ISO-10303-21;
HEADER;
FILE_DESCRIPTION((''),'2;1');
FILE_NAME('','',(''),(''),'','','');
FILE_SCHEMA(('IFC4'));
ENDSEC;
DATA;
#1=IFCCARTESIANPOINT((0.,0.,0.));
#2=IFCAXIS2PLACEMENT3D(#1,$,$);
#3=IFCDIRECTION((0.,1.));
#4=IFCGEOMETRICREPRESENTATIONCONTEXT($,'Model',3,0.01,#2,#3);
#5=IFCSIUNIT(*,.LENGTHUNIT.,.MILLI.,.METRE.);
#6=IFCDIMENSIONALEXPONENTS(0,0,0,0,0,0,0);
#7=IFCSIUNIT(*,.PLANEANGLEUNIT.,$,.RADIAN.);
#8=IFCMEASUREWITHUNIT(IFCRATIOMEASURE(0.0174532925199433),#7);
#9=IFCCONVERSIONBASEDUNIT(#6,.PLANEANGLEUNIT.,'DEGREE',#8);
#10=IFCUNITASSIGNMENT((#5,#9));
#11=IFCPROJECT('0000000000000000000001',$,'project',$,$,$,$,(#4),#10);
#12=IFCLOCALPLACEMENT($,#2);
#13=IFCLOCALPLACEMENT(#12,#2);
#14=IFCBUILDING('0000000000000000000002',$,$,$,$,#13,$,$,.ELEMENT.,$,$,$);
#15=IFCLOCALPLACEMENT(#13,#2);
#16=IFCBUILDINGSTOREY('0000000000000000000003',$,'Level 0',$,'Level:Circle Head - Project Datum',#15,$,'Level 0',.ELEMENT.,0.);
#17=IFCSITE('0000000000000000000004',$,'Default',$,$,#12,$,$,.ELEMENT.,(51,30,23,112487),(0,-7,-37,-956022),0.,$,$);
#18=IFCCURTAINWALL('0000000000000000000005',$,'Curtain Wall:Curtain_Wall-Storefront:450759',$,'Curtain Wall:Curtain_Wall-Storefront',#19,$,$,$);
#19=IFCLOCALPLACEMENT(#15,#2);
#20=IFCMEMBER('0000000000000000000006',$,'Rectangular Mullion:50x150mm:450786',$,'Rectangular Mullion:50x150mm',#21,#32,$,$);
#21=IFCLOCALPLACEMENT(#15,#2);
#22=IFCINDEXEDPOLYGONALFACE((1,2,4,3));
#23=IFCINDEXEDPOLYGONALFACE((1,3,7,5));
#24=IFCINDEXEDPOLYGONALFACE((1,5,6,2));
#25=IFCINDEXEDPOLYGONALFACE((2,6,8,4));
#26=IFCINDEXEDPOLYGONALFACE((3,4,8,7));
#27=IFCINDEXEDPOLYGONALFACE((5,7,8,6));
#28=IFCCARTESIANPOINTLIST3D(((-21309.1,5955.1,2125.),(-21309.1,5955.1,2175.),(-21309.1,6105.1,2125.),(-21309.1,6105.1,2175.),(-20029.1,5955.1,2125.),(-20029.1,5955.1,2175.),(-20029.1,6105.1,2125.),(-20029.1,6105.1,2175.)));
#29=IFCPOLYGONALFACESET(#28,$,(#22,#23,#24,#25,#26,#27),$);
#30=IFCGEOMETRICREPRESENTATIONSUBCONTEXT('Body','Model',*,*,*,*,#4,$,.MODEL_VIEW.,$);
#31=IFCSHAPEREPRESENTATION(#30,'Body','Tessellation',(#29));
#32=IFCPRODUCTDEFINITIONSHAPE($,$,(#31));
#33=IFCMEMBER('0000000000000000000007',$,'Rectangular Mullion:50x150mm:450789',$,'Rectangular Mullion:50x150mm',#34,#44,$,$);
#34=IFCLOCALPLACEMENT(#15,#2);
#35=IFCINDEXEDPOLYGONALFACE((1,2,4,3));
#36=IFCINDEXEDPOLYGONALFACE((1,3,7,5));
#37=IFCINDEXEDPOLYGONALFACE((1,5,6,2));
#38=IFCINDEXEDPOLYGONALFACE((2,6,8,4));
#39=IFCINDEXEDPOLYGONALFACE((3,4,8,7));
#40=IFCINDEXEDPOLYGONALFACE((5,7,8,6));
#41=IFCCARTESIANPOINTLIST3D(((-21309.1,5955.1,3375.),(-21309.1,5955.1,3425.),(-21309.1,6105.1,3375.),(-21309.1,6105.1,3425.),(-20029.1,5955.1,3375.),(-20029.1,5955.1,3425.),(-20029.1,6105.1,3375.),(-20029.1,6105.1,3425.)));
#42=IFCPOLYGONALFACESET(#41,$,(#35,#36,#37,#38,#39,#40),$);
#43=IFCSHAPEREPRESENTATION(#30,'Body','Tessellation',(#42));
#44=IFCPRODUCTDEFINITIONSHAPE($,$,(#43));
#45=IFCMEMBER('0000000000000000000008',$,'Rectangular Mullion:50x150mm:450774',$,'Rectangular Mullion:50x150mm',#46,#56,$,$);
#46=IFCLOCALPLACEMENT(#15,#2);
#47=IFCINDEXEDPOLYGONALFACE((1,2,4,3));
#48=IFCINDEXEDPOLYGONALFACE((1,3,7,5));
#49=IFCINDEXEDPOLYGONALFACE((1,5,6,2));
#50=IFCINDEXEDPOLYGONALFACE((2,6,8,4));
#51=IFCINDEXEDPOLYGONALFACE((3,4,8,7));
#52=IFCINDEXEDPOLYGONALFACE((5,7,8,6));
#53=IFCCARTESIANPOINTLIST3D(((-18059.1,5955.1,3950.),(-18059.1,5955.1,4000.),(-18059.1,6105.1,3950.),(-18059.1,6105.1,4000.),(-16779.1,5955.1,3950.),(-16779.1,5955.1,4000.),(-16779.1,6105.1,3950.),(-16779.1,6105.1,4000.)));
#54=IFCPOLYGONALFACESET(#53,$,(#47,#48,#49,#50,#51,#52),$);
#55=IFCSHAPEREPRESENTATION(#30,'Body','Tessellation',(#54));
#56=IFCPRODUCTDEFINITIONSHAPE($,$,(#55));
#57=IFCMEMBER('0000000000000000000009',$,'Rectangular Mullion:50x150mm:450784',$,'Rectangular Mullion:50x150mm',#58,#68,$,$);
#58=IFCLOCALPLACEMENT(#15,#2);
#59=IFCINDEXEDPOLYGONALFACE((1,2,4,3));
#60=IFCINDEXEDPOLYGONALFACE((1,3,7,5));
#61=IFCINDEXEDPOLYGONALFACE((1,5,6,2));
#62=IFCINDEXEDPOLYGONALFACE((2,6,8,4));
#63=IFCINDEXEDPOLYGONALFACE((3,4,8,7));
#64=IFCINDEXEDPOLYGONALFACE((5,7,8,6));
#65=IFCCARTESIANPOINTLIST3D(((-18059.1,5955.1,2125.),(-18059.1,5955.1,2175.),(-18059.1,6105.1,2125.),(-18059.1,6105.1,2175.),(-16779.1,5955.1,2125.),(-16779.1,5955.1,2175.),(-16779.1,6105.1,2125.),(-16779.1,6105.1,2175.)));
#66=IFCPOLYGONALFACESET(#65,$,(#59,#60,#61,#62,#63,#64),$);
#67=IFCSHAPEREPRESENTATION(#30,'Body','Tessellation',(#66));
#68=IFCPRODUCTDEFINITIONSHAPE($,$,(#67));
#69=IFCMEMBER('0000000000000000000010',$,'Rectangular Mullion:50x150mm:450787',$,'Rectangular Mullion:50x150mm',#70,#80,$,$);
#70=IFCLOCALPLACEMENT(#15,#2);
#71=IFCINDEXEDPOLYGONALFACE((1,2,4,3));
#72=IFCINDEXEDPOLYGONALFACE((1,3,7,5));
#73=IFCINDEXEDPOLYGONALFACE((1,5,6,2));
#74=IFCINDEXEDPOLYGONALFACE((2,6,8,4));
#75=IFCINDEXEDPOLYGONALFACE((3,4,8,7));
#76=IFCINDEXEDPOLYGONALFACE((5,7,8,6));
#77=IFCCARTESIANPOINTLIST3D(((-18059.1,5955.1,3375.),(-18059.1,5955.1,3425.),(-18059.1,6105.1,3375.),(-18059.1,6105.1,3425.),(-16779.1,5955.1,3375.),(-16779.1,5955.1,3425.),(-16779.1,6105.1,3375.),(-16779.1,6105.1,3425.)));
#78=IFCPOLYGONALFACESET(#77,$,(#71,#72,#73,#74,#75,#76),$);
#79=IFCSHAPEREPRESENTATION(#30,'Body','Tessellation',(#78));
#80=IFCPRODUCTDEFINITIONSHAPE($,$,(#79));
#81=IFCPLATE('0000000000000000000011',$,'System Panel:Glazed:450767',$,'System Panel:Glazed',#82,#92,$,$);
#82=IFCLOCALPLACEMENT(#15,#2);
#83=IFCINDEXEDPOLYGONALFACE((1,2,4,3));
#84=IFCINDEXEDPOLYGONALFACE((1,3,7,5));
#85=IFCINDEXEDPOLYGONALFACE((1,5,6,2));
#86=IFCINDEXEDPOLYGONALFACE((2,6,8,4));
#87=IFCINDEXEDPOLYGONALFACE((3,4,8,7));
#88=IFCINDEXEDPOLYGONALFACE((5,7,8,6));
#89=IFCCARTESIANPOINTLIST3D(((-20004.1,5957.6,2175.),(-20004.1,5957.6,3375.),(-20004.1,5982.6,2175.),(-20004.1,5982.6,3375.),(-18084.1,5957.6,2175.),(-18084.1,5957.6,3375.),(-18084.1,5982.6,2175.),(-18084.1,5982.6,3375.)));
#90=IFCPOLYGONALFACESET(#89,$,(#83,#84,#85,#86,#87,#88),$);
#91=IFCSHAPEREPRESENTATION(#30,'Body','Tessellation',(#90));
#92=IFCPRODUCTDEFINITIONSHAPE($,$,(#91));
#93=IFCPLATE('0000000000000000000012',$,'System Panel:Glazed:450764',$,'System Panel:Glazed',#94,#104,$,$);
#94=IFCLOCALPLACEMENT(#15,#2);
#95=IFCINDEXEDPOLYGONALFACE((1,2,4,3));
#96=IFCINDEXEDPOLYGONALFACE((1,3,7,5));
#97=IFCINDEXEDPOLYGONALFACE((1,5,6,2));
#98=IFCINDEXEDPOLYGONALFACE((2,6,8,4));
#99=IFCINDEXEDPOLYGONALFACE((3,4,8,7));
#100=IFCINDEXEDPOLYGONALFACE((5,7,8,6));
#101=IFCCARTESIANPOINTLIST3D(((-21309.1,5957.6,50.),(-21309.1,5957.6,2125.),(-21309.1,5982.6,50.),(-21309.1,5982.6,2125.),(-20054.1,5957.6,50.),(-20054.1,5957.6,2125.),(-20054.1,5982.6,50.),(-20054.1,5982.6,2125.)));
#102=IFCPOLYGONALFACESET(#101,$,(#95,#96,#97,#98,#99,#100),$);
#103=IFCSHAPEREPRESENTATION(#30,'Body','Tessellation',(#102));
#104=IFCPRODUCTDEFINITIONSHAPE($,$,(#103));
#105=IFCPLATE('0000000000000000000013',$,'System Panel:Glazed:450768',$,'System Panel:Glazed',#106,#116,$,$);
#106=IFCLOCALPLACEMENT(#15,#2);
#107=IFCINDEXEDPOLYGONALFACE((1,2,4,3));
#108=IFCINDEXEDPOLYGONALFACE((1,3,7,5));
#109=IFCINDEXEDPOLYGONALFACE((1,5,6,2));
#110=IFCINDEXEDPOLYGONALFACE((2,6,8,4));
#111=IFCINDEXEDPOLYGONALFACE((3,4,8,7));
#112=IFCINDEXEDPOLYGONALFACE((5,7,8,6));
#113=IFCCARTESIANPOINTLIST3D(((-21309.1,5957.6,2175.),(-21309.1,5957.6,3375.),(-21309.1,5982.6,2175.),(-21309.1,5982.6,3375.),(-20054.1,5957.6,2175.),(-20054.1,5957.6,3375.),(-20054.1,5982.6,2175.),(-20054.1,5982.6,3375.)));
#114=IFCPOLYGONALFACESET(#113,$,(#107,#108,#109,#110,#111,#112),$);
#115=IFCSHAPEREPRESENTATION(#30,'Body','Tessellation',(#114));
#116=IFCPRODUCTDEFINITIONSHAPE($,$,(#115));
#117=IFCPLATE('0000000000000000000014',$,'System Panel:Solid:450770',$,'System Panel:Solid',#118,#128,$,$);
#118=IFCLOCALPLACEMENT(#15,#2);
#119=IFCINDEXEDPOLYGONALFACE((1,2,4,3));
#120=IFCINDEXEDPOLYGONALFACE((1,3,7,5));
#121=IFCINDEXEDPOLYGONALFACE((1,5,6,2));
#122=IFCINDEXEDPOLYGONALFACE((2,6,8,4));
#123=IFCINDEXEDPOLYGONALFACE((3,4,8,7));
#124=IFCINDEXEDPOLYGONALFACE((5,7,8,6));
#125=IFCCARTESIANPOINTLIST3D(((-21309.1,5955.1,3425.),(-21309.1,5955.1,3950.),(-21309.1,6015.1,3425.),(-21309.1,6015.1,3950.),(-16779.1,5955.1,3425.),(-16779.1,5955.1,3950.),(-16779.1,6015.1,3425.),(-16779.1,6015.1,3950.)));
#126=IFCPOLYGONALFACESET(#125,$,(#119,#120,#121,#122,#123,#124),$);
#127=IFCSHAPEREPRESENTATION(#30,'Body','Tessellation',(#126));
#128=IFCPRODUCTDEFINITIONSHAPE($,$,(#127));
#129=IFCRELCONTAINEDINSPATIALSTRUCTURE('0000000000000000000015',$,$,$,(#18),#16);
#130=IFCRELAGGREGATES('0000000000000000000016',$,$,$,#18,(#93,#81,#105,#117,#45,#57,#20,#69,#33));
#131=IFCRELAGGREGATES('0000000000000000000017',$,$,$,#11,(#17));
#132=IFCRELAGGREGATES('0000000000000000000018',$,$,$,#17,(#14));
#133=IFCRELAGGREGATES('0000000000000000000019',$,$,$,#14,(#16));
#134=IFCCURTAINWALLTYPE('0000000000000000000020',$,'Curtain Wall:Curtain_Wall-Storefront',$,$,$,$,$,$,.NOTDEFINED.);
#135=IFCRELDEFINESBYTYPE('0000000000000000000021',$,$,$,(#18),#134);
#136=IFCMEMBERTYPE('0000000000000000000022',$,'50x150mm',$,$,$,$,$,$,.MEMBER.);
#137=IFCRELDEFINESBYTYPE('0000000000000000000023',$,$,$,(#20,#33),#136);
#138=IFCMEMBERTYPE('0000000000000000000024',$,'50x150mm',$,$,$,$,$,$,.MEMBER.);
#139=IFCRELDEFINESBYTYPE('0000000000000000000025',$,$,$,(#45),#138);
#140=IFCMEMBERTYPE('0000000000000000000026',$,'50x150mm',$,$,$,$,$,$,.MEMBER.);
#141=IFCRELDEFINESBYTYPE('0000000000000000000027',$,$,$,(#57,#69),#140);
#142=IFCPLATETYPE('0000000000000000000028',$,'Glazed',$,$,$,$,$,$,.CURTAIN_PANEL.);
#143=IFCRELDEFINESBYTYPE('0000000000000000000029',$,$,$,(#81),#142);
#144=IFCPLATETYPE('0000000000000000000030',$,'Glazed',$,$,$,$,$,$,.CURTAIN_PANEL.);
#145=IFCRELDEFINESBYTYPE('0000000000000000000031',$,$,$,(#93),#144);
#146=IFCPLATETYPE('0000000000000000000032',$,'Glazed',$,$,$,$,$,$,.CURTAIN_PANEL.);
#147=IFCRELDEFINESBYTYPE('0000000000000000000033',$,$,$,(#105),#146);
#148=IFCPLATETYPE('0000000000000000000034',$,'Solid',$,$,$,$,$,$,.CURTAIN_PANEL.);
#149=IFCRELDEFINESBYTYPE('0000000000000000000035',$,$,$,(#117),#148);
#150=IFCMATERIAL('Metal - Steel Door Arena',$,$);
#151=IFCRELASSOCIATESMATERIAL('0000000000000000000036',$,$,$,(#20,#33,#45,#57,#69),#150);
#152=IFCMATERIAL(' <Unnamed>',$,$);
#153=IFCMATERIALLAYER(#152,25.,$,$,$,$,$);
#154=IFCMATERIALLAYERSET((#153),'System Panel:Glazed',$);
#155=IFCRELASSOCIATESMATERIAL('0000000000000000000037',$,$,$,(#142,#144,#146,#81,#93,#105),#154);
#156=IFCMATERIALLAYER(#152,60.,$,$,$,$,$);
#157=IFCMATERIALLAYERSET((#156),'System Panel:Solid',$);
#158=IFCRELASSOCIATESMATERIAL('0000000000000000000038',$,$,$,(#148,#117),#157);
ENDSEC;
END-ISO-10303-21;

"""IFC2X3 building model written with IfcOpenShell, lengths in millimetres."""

from ifc_helpers import new_model, entity, si_unit, converted_unit, direction, frame, frame_2d, origin, origin_2d_with_axis, place, context, subcontext, project, spatial, rectangle, extrude, source, transform, mapped, material, layer, layer_set, layer_usage, type_object, type_shapes, element, aggregate, save


model = new_model("IFC2X3")

# Units and contexts
model_context = context("Model", 3, precision=0.01, world=origin(), true_north=direction((0.0, 1.0)))
body_context = subcontext(model_context, "Body", "Model", "MODEL_VIEW")
ifc_project = project(units=[si_unit("LENGTHUNIT", "METRE", prefix="MILLI"), converted_unit("PLANEANGLEUNIT", "DEGREE", entity("IfcRatioMeasure", 0.0174532925199433), si_unit("PLANEANGLEUNIT", "RADIAN"), dimensions=[0, 0, 0, 0, 0, 0, 0])], contexts=[model_context])

# Site, building, storey
site_placement = place(None, origin())
site = spatial("IfcSite", under=ifc_project, at=site_placement, Name="Default", CompositionType="ELEMENT", RefLatitude=(51, 30, 23, 112487), RefLongitude=(0, -7, -37, -956022), RefElevation=0.0)
building_placement = place(site_placement, origin())
building = spatial("IfcBuilding", under=site, at=building_placement, CompositionType="ELEMENT")
storey_placement = place(building_placement, origin())
storey = spatial("IfcBuildingStorey", under=building, at=storey_placement, Name="Level 0", ObjectType="Level:Circle Head - Project Datum", LongName="Level 0", CompositionType="ELEMENT", Elevation=0.0)

# Curtain wall, members, plates
curtain_wall_type = type_object("IfcCurtainWallType", Name="Curtain Wall:Curtain_Wall-Storefront", PredefinedType="NOTDEFINED")
curtain_wall_placement = place(storey_placement, origin())
curtain_wall = element("IfcCurtainWall", 1, at=curtain_wall_placement, inside=storey, type_object=curtain_wall_type, Name="Curtain Wall:Curtain_Wall-Storefront:450759", ObjectType="Curtain Wall:Curtain_Wall-Storefront")
ifc_material_1 = material(Name="Metal - Steel Door Arena")
member_type_1 = type_object("IfcMemberType", Name="50x150mm", PredefinedType="MEMBER")
shared_shape_1 = source(origin(), body_context, "Body", "SweptSolid", [
    extrude(rectangle(XDim=150.0, YDim=50.0, at=origin_2d_with_axis()), frame((0.0, 0.0, -1280.0), z_axis=(0.0, 0.0, 1.0), x_axis=(0.0, -1.0, 0.0)), (0.0, 0.0, 1.0), 1280.0),
])
type_shapes(member_type_1, [shared_shape_1])
member_1_placement = place(storey_placement, frame((-21309.1, 6030.1, 2150.0), z_axis=(-1.0, 0.0, 0.0), x_axis=(0.0, 0.0, 1.0)))
member_1 = element("IfcMember", 2, at=member_1_placement, type_object=member_type_1, material=ifc_material_1, Name="Rectangular Mullion:50x150mm:450786", ObjectType="Rectangular Mullion:50x150mm", context=body_context, shape_type="MappedRepresentation", body=[
    mapped(shared_shape_1, transform((0.0, 0.0, 0.0), scale=1.0)),
])
member_2_placement = place(storey_placement, frame((-21309.1, 6030.1, 3400.0), z_axis=(-1.0, 0.0, 0.0), x_axis=(0.0, 0.0, 1.0)))
member_2 = element("IfcMember", 3, at=member_2_placement, type_object=member_type_1, material=ifc_material_1, Name="Rectangular Mullion:50x150mm:450789", ObjectType="Rectangular Mullion:50x150mm", context=body_context, shape_type="MappedRepresentation", body=[
    mapped(shared_shape_1, transform((0.0, 0.0, 0.0), scale=1.0)),
])
member_type_2 = type_object("IfcMemberType", Name="50x150mm", PredefinedType="MEMBER")
shared_shape_2 = source(origin(), body_context, "Body", "SweptSolid", [
    extrude(rectangle(XDim=150.0, YDim=50.0, at=origin_2d_with_axis()), frame((-25.0, 0.0, -1280.0), z_axis=(0.0, 0.0, 1.0), x_axis=(0.0, -1.0, 0.0)), (0.0, 0.0, 1.0), 1280.0),
])
type_shapes(member_type_2, [shared_shape_2])
member_3_placement = place(storey_placement, frame((-18059.1, 6030.1, 4000.0), z_axis=(-1.0, 0.0, 0.0), x_axis=(0.0, 0.0, 1.0)))
member_3 = element("IfcMember", 4, at=member_3_placement, type_object=member_type_2, material=ifc_material_1, Name="Rectangular Mullion:50x150mm:450774", ObjectType="Rectangular Mullion:50x150mm", context=body_context, shape_type="MappedRepresentation", body=[
    mapped(shared_shape_2, transform((0.0, 0.0, 0.0), scale=1.0)),
])
member_type_3 = type_object("IfcMemberType", Name="50x150mm", PredefinedType="MEMBER")
shared_shape_3 = source(origin(), body_context, "Body", "SweptSolid", [
    extrude(rectangle(XDim=150.0, YDim=50.0, at=origin_2d_with_axis()), frame((0.0, 0.0, -1280.0), z_axis=(0.0, 0.0, 1.0), x_axis=(0.0, -1.0, 0.0)), (0.0, 0.0, 1.0), 1280.0),
])
type_shapes(member_type_3, [shared_shape_3])
member_4_placement = place(storey_placement, frame((-18059.1, 6030.1, 2150.0), z_axis=(-1.0, 0.0, 0.0), x_axis=(0.0, 0.0, 1.0)))
member_4 = element("IfcMember", 5, at=member_4_placement, type_object=member_type_3, material=ifc_material_1, Name="Rectangular Mullion:50x150mm:450784", ObjectType="Rectangular Mullion:50x150mm", context=body_context, shape_type="MappedRepresentation", body=[
    mapped(shared_shape_3, transform((0.0, 0.0, 0.0), scale=1.0)),
])
member_5_placement = place(storey_placement, frame((-18059.1, 6030.1, 3400.0), z_axis=(-1.0, 0.0, 0.0), x_axis=(0.0, 0.0, 1.0)))
member_5 = element("IfcMember", 6, at=member_5_placement, type_object=member_type_3, material=ifc_material_1, Name="Rectangular Mullion:50x150mm:450787", ObjectType="Rectangular Mullion:50x150mm", context=body_context, shape_type="MappedRepresentation", body=[
    mapped(shared_shape_3, transform((0.0, 0.0, 0.0), scale=1.0)),
])
ifc_material_2 = material(Name=" <Unnamed>")
ifc_layer_1 = layer(ifc_material_2, 25.0)
ifc_layer_set_1 = layer_set([ifc_layer_1], Name="System Panel:Glazed")
ifc_layer_usage_1 = layer_usage(ifc_layer_set_1, "AXIS3", "POSITIVE", 0.2)
plate_type_1 = type_object("IfcPlateType", Name="Glazed", PredefinedType="CURTAIN_PANEL", material=ifc_layer_set_1)
shared_shape_4 = source(origin(), body_context, "Body", "SweptSolid", [
    extrude(rectangle(XDim=25.0, YDim=1920.0, at=origin_2d_with_axis()), frame((0.0, 60.0, 0.0), z_axis=(0.0, 0.0, 1.0), x_axis=(0.0, 1.0, 0.0)), (0.0, 0.0, 1.0), 1200.0),
])
type_shapes(plate_type_1, [shared_shape_4])
plate_1_placement = place(curtain_wall_placement, frame((-19044.1, 6030.1, 2175.0), z_axis=(0.0, 0.0, 1.0), x_axis=(-1.0, 0.0, 0.0)))
plate_1 = element("IfcPlate", 7, at=plate_1_placement, type_object=plate_type_1, material=ifc_layer_usage_1, Name="System Panel:Glazed:450767", ObjectType="System Panel:Glazed", context=body_context, shape_type="MappedRepresentation", body=[
    mapped(shared_shape_4, transform((0.0, 0.0, 0.0), scale=1.0)),
])
ifc_layer_usage_2 = layer_usage(ifc_layer_set_1, "AXIS3", "POSITIVE", 0.2)
plate_type_2 = type_object("IfcPlateType", Name="Glazed", PredefinedType="CURTAIN_PANEL", material=ifc_layer_set_1)
shared_shape_5 = source(origin(), body_context, "Body", "SweptSolid", [
    extrude(rectangle(XDim=25.0, YDim=1255.0, at=origin_2d_with_axis()), frame((0.0, 60.0, 0.0), z_axis=(0.0, 0.0, 1.0), x_axis=(0.0, 1.0, 0.0)), (0.0, 0.0, 1.0), 2075.0),
])
type_shapes(plate_type_2, [shared_shape_5])
plate_2_placement = place(curtain_wall_placement, frame((-20681.6, 6030.1, 50.0), z_axis=(0.0, 0.0, 1.0), x_axis=(-1.0, 0.0, 0.0)))
plate_2 = element("IfcPlate", 8, at=plate_2_placement, type_object=plate_type_2, material=ifc_layer_usage_2, Name="System Panel:Glazed:450764", ObjectType="System Panel:Glazed", context=body_context, shape_type="MappedRepresentation", body=[
    mapped(shared_shape_5, transform((0.0, 0.0, 0.0), scale=1.0)),
])
ifc_layer_usage_3 = layer_usage(ifc_layer_set_1, "AXIS3", "POSITIVE", 0.2)
plate_type_3 = type_object("IfcPlateType", Name="Glazed", PredefinedType="CURTAIN_PANEL", material=ifc_layer_set_1)
shared_shape_6 = source(origin(), body_context, "Body", "SweptSolid", [
    extrude(rectangle(XDim=25.0, YDim=1255.0, at=origin_2d_with_axis()), frame((0.0, 60.0, 0.0), z_axis=(0.0, 0.0, 1.0), x_axis=(0.0, 1.0, 0.0)), (0.0, 0.0, 1.0), 1200.0),
])
type_shapes(plate_type_3, [shared_shape_6])
plate_3_placement = place(curtain_wall_placement, frame((-20681.6, 6030.1, 2175.0), z_axis=(0.0, 0.0, 1.0), x_axis=(-1.0, 0.0, 0.0)))
plate_3 = element("IfcPlate", 9, at=plate_3_placement, type_object=plate_type_3, material=ifc_layer_usage_3, Name="System Panel:Glazed:450768", ObjectType="System Panel:Glazed", context=body_context, shape_type="MappedRepresentation", body=[
    mapped(shared_shape_6, transform((0.0, 0.0, 0.0), scale=1.0)),
])
ifc_layer_2 = layer(ifc_material_2, 60.0)
ifc_layer_set_2 = layer_set([ifc_layer_2], Name="System Panel:Solid")
ifc_layer_usage_4 = layer_usage(ifc_layer_set_2, "AXIS3", "POSITIVE", 0.1)
plate_type_4 = type_object("IfcPlateType", Name="Solid", PredefinedType="CURTAIN_PANEL", material=ifc_layer_set_2)
shared_shape_7 = source(origin(), body_context, "Body", "SweptSolid", [
    extrude(rectangle(XDim=525.0, YDim=4530.0, at=frame_2d((0.0, 0.0), x_axis=(1.0, 0.0))), frame((0.0, 15.0, 262.5), z_axis=(0.0, 1.0, 0.0), x_axis=(0.0, 0.0, 1.0)), (0.0, 0.0, 1.0), 60.0),
])
type_shapes(plate_type_4, [shared_shape_7])
plate_4_placement = place(curtain_wall_placement, frame((-19044.1, 6030.1, 3425.0), z_axis=(0.0, 0.0, 1.0), x_axis=(-1.0, 0.0, 0.0)))
plate_4 = element("IfcPlate", 10, at=plate_4_placement, type_object=plate_type_4, material=ifc_layer_usage_4, Name="System Panel:Solid:450770", ObjectType="System Panel:Solid", context=body_context, shape_type="MappedRepresentation", body=[
    mapped(shared_shape_7, transform((0.0, 0.0, 0.0), scale=1.0)),
])
aggregate(curtain_wall, [plate_2, plate_1, plate_3, plate_4, member_3, member_4, member_1, member_5, member_2])

save(model, "model.ifc")
